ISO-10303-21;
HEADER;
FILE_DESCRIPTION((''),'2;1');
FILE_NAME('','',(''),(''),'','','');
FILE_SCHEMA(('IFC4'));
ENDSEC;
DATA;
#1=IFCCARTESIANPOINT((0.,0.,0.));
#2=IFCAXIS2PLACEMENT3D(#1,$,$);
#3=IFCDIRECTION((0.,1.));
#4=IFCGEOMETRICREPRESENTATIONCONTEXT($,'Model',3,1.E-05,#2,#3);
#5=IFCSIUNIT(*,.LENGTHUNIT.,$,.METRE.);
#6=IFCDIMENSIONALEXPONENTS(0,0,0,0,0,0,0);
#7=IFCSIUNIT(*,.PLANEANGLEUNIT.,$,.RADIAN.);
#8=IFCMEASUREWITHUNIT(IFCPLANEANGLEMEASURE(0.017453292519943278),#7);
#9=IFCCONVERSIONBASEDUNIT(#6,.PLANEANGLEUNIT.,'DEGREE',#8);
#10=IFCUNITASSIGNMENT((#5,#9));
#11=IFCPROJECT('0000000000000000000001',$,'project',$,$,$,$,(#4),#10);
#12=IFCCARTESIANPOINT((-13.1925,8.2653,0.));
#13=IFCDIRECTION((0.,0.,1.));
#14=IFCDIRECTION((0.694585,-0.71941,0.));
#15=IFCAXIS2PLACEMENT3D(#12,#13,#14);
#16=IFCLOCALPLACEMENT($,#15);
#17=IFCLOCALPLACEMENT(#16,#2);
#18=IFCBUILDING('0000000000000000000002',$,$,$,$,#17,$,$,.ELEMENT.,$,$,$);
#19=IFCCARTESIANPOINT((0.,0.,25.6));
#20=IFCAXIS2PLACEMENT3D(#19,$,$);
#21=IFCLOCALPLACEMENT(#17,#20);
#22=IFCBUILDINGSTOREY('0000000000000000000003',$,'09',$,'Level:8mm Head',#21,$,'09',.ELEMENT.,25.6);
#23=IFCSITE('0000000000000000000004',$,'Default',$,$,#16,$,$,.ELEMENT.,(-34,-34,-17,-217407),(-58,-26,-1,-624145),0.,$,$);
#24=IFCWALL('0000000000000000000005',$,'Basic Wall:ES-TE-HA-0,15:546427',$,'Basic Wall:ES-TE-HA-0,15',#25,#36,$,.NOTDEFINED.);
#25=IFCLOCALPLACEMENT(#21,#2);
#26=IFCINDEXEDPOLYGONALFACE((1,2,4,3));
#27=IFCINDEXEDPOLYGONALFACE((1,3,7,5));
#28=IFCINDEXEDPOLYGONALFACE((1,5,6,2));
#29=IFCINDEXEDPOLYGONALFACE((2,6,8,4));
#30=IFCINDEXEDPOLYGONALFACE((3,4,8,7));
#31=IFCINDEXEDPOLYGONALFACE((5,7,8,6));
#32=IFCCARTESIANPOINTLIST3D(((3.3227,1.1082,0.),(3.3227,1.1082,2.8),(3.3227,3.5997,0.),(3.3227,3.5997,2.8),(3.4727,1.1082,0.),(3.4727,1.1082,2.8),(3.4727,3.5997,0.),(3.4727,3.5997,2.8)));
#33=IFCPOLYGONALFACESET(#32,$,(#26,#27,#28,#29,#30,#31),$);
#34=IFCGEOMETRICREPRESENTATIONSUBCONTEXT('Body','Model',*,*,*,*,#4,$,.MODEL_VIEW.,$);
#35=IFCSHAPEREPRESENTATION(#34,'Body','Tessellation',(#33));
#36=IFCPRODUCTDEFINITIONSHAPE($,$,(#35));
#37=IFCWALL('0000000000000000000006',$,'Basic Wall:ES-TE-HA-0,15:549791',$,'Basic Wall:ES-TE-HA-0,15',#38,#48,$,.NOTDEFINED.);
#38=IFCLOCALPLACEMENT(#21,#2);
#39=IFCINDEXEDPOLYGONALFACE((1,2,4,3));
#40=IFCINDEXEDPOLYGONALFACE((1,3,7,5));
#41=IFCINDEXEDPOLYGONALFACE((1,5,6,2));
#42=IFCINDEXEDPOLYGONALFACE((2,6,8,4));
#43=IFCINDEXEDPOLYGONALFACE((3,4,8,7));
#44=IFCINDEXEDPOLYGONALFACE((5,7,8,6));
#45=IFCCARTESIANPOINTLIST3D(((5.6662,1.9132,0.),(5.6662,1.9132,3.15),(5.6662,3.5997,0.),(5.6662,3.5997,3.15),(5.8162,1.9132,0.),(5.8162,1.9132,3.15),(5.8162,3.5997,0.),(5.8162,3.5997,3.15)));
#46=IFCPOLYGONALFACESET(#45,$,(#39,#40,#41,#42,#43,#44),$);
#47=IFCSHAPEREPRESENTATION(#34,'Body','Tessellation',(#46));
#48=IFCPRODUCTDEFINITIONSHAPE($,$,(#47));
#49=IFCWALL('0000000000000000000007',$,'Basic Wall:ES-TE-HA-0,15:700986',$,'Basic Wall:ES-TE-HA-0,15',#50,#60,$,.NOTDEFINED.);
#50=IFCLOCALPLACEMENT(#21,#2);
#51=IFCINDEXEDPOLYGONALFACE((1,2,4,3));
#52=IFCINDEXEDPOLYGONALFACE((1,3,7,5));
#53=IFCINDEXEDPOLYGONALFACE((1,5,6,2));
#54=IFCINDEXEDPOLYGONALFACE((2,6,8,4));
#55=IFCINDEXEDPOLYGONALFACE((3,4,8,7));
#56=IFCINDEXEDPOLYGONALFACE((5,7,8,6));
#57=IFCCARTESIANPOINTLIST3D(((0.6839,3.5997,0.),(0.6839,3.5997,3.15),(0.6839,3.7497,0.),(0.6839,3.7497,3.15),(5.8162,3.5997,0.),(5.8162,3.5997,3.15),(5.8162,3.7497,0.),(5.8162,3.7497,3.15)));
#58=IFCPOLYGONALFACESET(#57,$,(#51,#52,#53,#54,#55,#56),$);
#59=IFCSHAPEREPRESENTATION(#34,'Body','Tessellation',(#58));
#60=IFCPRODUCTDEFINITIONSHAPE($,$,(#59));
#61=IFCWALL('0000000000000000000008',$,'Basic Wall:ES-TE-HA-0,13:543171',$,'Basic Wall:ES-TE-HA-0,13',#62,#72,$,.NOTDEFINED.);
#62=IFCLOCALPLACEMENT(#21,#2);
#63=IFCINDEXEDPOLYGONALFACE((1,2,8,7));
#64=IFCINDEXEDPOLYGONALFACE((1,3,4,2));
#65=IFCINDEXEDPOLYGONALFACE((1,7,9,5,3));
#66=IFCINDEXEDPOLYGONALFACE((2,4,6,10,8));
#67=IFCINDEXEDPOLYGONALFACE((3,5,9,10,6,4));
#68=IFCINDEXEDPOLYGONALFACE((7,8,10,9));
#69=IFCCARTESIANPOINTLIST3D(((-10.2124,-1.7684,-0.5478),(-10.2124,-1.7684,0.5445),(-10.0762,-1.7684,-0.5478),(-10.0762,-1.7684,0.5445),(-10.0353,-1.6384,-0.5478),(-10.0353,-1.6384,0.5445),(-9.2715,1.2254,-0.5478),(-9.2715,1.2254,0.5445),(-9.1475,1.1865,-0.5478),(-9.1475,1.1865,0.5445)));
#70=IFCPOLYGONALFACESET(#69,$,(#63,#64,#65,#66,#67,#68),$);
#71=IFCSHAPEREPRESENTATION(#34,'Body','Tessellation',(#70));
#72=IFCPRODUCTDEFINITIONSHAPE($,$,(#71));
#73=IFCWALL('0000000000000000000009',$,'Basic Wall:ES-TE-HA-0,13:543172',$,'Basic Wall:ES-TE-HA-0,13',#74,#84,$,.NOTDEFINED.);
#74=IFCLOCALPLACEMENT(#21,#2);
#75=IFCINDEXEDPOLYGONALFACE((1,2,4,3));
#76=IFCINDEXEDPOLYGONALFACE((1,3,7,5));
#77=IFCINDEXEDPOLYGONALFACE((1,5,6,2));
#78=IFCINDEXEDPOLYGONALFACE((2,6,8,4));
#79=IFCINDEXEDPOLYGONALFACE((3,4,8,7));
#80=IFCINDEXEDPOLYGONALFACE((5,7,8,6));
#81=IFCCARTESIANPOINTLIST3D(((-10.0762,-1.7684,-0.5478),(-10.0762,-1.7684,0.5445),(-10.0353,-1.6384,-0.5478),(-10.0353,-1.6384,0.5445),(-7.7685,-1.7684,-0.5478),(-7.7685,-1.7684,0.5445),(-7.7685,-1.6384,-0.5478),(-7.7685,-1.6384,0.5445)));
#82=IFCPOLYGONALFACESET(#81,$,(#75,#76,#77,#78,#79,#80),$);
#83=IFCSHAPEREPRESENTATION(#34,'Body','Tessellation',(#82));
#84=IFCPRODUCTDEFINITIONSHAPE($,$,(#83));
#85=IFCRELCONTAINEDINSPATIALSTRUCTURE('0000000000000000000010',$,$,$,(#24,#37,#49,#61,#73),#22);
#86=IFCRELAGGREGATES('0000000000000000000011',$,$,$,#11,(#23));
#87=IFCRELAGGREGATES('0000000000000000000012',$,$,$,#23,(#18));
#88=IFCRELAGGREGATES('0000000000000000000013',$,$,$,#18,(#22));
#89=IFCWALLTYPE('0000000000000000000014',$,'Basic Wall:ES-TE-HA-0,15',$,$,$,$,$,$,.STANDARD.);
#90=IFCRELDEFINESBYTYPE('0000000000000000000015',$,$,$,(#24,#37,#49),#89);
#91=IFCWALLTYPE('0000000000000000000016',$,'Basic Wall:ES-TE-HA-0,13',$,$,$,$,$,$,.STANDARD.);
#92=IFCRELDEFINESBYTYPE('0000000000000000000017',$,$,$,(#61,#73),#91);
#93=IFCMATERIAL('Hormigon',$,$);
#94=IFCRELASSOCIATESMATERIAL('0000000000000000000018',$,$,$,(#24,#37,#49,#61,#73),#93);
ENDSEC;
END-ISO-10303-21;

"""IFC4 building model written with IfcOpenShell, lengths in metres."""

from ifc_helpers import new_model, entity, si_unit, converted_unit, direction, frame, origin, place, context, subcontext, project, spatial, indexed_curve, outline, extrude, material, type_object, element, save


model = new_model("IFC4")

# Units and contexts
model_context = context("Model", 3, precision=1e-05, world=origin(), true_north=direction((0.0, 1.0)))
body_context = subcontext(model_context, "Body", "Model", "MODEL_VIEW")
ifc_project = project(units=[si_unit("LENGTHUNIT", "METRE"), converted_unit("PLANEANGLEUNIT", "DEGREE", entity("IfcPlaneAngleMeasure", 0.017453292519943278), si_unit("PLANEANGLEUNIT", "RADIAN"), dimensions=[0, 0, 0, 0, 0, 0, 0])], contexts=[model_context])

# Site, building, storey
site_placement = place(None, frame((-13.1925, 8.2653, 0.0), z_axis=(0.0, 0.0, 1.0), x_axis=(0.694585, -0.71941, 0.0)))
site = spatial("IfcSite", under=ifc_project, at=site_placement, Name="Default", CompositionType="ELEMENT", RefLatitude=(-34, -34, -17, -217407), RefLongitude=(-58, -26, -1, -624145), RefElevation=0.0)
building_placement = place(site_placement, origin())
building = spatial("IfcBuilding", under=site, at=building_placement, CompositionType="ELEMENT")
storey_placement = place(building_placement, frame((0.0, 0.0, 25.6)))
storey = spatial("IfcBuildingStorey", under=building, at=storey_placement, Name="09", ObjectType="Level:8mm Head", LongName="09", CompositionType="ELEMENT", Elevation=25.6)

# Shared definitions
ifc_material_1 = material(Name="Hormigon")

# Walls
wall_type_1 = type_object("IfcWallType", Name="Basic Wall:ES-TE-HA-0,15", PredefinedType="STANDARD")
wall_1_placement = place(storey_placement, frame((3.3977, 3.5997, 0.0), z_axis=(0.0, 0.0, 1.0), x_axis=(0.0, -1.0, 0.0)))
element("IfcWall", 1, at=wall_1_placement, inside=storey, type_object=wall_type_1, material=ifc_material_1, Name="Basic Wall:ES-TE-HA-0,15:546427", ObjectType="Basic Wall:ES-TE-HA-0,15", PredefinedType="NOTDEFINED", context=body_context, shape_type="SweptSolid", body=[
    extrude(outline(indexed_curve([(2.4914, 0.075), (0.0, 0.075), (0.0, -0.075), (2.4914, -0.075), (2.4914, 0.075)], self_intersect=False)), origin(), (0.0, 0.0, 1.0), 2.8),
])
wall_2_placement = place(storey_placement, frame((5.7412, 3.5997, 0.0), z_axis=(0.0, 0.0, 1.0), x_axis=(0.0, -1.0, 0.0)))
element("IfcWall", 2, at=wall_2_placement, inside=storey, type_object=wall_type_1, material=ifc_material_1, Name="Basic Wall:ES-TE-HA-0,15:549791", ObjectType="Basic Wall:ES-TE-HA-0,15", PredefinedType="NOTDEFINED", context=body_context, shape_type="SweptSolid", body=[
    extrude(outline(indexed_curve([(1.6864, 0.075), (0.0, 0.075), (0.0, -0.075), (1.6864, -0.075), (1.6864, 0.075)], self_intersect=False)), origin(), (0.0, 0.0, 1.0), 3.15),
])
wall_3_placement = place(storey_placement, frame((0.6839, 3.6747, 0.0)))
element("IfcWall", 3, at=wall_3_placement, inside=storey, type_object=wall_type_1, material=ifc_material_1, Name="Basic Wall:ES-TE-HA-0,15:700986", ObjectType="Basic Wall:ES-TE-HA-0,15", PredefinedType="NOTDEFINED", context=body_context, shape_type="SweptSolid", body=[
    extrude(outline(indexed_curve([(5.1323, 0.075), (0.0, 0.075), (0.0, -0.075), (5.1323, -0.075), (5.1323, 0.075)], self_intersect=False)), origin(), (0.0, 0.0, 1.0), 3.15),
])
wall_type_2 = type_object("IfcWallType", Name="Basic Wall:ES-TE-HA-0,13", PredefinedType="STANDARD")
wall_4_placement = place(storey_placement, frame((-10.1504, -1.7879, -0.5478), z_axis=(0.0, 0.0, 1.0), x_axis=(0.299835, 0.953991, 0.0)))
element("IfcWall", 4, at=wall_4_placement, inside=storey, type_object=wall_type_2, material=ifc_material_1, Name="Basic Wall:ES-TE-HA-0,13:543171", ObjectType="Basic Wall:ES-TE-HA-0,13", PredefinedType="NOTDEFINED", context=body_context, shape_type="SweptSolid", body=[
    extrude(outline(indexed_curve([(3.1382, -0.065), (3.1382, 0.065), (0.0, 0.065), (0.0409, -0.065), (0.1771, -0.065), (3.1382, -0.065)], self_intersect=False)), origin(), (0.0, 0.0, 1.0), 1.0923),
])
wall_5_placement = place(storey_placement, frame((-10.0762, -1.7034, -0.5478)))
element("IfcWall", 5, at=wall_5_placement, inside=storey, type_object=wall_type_2, material=ifc_material_1, Name="Basic Wall:ES-TE-HA-0,13:543172", ObjectType="Basic Wall:ES-TE-HA-0,13", PredefinedType="NOTDEFINED", context=body_context, shape_type="SweptSolid", body=[
    extrude(outline(indexed_curve([(2.3077, -0.065), (2.3077, 0.065), (0.0409, 0.065), (0.0, -0.065), (2.3077, -0.065)], self_intersect=False)), origin(), (0.0, 0.0, 1.0), 1.0923),
])

save(model, "model.ifc")
